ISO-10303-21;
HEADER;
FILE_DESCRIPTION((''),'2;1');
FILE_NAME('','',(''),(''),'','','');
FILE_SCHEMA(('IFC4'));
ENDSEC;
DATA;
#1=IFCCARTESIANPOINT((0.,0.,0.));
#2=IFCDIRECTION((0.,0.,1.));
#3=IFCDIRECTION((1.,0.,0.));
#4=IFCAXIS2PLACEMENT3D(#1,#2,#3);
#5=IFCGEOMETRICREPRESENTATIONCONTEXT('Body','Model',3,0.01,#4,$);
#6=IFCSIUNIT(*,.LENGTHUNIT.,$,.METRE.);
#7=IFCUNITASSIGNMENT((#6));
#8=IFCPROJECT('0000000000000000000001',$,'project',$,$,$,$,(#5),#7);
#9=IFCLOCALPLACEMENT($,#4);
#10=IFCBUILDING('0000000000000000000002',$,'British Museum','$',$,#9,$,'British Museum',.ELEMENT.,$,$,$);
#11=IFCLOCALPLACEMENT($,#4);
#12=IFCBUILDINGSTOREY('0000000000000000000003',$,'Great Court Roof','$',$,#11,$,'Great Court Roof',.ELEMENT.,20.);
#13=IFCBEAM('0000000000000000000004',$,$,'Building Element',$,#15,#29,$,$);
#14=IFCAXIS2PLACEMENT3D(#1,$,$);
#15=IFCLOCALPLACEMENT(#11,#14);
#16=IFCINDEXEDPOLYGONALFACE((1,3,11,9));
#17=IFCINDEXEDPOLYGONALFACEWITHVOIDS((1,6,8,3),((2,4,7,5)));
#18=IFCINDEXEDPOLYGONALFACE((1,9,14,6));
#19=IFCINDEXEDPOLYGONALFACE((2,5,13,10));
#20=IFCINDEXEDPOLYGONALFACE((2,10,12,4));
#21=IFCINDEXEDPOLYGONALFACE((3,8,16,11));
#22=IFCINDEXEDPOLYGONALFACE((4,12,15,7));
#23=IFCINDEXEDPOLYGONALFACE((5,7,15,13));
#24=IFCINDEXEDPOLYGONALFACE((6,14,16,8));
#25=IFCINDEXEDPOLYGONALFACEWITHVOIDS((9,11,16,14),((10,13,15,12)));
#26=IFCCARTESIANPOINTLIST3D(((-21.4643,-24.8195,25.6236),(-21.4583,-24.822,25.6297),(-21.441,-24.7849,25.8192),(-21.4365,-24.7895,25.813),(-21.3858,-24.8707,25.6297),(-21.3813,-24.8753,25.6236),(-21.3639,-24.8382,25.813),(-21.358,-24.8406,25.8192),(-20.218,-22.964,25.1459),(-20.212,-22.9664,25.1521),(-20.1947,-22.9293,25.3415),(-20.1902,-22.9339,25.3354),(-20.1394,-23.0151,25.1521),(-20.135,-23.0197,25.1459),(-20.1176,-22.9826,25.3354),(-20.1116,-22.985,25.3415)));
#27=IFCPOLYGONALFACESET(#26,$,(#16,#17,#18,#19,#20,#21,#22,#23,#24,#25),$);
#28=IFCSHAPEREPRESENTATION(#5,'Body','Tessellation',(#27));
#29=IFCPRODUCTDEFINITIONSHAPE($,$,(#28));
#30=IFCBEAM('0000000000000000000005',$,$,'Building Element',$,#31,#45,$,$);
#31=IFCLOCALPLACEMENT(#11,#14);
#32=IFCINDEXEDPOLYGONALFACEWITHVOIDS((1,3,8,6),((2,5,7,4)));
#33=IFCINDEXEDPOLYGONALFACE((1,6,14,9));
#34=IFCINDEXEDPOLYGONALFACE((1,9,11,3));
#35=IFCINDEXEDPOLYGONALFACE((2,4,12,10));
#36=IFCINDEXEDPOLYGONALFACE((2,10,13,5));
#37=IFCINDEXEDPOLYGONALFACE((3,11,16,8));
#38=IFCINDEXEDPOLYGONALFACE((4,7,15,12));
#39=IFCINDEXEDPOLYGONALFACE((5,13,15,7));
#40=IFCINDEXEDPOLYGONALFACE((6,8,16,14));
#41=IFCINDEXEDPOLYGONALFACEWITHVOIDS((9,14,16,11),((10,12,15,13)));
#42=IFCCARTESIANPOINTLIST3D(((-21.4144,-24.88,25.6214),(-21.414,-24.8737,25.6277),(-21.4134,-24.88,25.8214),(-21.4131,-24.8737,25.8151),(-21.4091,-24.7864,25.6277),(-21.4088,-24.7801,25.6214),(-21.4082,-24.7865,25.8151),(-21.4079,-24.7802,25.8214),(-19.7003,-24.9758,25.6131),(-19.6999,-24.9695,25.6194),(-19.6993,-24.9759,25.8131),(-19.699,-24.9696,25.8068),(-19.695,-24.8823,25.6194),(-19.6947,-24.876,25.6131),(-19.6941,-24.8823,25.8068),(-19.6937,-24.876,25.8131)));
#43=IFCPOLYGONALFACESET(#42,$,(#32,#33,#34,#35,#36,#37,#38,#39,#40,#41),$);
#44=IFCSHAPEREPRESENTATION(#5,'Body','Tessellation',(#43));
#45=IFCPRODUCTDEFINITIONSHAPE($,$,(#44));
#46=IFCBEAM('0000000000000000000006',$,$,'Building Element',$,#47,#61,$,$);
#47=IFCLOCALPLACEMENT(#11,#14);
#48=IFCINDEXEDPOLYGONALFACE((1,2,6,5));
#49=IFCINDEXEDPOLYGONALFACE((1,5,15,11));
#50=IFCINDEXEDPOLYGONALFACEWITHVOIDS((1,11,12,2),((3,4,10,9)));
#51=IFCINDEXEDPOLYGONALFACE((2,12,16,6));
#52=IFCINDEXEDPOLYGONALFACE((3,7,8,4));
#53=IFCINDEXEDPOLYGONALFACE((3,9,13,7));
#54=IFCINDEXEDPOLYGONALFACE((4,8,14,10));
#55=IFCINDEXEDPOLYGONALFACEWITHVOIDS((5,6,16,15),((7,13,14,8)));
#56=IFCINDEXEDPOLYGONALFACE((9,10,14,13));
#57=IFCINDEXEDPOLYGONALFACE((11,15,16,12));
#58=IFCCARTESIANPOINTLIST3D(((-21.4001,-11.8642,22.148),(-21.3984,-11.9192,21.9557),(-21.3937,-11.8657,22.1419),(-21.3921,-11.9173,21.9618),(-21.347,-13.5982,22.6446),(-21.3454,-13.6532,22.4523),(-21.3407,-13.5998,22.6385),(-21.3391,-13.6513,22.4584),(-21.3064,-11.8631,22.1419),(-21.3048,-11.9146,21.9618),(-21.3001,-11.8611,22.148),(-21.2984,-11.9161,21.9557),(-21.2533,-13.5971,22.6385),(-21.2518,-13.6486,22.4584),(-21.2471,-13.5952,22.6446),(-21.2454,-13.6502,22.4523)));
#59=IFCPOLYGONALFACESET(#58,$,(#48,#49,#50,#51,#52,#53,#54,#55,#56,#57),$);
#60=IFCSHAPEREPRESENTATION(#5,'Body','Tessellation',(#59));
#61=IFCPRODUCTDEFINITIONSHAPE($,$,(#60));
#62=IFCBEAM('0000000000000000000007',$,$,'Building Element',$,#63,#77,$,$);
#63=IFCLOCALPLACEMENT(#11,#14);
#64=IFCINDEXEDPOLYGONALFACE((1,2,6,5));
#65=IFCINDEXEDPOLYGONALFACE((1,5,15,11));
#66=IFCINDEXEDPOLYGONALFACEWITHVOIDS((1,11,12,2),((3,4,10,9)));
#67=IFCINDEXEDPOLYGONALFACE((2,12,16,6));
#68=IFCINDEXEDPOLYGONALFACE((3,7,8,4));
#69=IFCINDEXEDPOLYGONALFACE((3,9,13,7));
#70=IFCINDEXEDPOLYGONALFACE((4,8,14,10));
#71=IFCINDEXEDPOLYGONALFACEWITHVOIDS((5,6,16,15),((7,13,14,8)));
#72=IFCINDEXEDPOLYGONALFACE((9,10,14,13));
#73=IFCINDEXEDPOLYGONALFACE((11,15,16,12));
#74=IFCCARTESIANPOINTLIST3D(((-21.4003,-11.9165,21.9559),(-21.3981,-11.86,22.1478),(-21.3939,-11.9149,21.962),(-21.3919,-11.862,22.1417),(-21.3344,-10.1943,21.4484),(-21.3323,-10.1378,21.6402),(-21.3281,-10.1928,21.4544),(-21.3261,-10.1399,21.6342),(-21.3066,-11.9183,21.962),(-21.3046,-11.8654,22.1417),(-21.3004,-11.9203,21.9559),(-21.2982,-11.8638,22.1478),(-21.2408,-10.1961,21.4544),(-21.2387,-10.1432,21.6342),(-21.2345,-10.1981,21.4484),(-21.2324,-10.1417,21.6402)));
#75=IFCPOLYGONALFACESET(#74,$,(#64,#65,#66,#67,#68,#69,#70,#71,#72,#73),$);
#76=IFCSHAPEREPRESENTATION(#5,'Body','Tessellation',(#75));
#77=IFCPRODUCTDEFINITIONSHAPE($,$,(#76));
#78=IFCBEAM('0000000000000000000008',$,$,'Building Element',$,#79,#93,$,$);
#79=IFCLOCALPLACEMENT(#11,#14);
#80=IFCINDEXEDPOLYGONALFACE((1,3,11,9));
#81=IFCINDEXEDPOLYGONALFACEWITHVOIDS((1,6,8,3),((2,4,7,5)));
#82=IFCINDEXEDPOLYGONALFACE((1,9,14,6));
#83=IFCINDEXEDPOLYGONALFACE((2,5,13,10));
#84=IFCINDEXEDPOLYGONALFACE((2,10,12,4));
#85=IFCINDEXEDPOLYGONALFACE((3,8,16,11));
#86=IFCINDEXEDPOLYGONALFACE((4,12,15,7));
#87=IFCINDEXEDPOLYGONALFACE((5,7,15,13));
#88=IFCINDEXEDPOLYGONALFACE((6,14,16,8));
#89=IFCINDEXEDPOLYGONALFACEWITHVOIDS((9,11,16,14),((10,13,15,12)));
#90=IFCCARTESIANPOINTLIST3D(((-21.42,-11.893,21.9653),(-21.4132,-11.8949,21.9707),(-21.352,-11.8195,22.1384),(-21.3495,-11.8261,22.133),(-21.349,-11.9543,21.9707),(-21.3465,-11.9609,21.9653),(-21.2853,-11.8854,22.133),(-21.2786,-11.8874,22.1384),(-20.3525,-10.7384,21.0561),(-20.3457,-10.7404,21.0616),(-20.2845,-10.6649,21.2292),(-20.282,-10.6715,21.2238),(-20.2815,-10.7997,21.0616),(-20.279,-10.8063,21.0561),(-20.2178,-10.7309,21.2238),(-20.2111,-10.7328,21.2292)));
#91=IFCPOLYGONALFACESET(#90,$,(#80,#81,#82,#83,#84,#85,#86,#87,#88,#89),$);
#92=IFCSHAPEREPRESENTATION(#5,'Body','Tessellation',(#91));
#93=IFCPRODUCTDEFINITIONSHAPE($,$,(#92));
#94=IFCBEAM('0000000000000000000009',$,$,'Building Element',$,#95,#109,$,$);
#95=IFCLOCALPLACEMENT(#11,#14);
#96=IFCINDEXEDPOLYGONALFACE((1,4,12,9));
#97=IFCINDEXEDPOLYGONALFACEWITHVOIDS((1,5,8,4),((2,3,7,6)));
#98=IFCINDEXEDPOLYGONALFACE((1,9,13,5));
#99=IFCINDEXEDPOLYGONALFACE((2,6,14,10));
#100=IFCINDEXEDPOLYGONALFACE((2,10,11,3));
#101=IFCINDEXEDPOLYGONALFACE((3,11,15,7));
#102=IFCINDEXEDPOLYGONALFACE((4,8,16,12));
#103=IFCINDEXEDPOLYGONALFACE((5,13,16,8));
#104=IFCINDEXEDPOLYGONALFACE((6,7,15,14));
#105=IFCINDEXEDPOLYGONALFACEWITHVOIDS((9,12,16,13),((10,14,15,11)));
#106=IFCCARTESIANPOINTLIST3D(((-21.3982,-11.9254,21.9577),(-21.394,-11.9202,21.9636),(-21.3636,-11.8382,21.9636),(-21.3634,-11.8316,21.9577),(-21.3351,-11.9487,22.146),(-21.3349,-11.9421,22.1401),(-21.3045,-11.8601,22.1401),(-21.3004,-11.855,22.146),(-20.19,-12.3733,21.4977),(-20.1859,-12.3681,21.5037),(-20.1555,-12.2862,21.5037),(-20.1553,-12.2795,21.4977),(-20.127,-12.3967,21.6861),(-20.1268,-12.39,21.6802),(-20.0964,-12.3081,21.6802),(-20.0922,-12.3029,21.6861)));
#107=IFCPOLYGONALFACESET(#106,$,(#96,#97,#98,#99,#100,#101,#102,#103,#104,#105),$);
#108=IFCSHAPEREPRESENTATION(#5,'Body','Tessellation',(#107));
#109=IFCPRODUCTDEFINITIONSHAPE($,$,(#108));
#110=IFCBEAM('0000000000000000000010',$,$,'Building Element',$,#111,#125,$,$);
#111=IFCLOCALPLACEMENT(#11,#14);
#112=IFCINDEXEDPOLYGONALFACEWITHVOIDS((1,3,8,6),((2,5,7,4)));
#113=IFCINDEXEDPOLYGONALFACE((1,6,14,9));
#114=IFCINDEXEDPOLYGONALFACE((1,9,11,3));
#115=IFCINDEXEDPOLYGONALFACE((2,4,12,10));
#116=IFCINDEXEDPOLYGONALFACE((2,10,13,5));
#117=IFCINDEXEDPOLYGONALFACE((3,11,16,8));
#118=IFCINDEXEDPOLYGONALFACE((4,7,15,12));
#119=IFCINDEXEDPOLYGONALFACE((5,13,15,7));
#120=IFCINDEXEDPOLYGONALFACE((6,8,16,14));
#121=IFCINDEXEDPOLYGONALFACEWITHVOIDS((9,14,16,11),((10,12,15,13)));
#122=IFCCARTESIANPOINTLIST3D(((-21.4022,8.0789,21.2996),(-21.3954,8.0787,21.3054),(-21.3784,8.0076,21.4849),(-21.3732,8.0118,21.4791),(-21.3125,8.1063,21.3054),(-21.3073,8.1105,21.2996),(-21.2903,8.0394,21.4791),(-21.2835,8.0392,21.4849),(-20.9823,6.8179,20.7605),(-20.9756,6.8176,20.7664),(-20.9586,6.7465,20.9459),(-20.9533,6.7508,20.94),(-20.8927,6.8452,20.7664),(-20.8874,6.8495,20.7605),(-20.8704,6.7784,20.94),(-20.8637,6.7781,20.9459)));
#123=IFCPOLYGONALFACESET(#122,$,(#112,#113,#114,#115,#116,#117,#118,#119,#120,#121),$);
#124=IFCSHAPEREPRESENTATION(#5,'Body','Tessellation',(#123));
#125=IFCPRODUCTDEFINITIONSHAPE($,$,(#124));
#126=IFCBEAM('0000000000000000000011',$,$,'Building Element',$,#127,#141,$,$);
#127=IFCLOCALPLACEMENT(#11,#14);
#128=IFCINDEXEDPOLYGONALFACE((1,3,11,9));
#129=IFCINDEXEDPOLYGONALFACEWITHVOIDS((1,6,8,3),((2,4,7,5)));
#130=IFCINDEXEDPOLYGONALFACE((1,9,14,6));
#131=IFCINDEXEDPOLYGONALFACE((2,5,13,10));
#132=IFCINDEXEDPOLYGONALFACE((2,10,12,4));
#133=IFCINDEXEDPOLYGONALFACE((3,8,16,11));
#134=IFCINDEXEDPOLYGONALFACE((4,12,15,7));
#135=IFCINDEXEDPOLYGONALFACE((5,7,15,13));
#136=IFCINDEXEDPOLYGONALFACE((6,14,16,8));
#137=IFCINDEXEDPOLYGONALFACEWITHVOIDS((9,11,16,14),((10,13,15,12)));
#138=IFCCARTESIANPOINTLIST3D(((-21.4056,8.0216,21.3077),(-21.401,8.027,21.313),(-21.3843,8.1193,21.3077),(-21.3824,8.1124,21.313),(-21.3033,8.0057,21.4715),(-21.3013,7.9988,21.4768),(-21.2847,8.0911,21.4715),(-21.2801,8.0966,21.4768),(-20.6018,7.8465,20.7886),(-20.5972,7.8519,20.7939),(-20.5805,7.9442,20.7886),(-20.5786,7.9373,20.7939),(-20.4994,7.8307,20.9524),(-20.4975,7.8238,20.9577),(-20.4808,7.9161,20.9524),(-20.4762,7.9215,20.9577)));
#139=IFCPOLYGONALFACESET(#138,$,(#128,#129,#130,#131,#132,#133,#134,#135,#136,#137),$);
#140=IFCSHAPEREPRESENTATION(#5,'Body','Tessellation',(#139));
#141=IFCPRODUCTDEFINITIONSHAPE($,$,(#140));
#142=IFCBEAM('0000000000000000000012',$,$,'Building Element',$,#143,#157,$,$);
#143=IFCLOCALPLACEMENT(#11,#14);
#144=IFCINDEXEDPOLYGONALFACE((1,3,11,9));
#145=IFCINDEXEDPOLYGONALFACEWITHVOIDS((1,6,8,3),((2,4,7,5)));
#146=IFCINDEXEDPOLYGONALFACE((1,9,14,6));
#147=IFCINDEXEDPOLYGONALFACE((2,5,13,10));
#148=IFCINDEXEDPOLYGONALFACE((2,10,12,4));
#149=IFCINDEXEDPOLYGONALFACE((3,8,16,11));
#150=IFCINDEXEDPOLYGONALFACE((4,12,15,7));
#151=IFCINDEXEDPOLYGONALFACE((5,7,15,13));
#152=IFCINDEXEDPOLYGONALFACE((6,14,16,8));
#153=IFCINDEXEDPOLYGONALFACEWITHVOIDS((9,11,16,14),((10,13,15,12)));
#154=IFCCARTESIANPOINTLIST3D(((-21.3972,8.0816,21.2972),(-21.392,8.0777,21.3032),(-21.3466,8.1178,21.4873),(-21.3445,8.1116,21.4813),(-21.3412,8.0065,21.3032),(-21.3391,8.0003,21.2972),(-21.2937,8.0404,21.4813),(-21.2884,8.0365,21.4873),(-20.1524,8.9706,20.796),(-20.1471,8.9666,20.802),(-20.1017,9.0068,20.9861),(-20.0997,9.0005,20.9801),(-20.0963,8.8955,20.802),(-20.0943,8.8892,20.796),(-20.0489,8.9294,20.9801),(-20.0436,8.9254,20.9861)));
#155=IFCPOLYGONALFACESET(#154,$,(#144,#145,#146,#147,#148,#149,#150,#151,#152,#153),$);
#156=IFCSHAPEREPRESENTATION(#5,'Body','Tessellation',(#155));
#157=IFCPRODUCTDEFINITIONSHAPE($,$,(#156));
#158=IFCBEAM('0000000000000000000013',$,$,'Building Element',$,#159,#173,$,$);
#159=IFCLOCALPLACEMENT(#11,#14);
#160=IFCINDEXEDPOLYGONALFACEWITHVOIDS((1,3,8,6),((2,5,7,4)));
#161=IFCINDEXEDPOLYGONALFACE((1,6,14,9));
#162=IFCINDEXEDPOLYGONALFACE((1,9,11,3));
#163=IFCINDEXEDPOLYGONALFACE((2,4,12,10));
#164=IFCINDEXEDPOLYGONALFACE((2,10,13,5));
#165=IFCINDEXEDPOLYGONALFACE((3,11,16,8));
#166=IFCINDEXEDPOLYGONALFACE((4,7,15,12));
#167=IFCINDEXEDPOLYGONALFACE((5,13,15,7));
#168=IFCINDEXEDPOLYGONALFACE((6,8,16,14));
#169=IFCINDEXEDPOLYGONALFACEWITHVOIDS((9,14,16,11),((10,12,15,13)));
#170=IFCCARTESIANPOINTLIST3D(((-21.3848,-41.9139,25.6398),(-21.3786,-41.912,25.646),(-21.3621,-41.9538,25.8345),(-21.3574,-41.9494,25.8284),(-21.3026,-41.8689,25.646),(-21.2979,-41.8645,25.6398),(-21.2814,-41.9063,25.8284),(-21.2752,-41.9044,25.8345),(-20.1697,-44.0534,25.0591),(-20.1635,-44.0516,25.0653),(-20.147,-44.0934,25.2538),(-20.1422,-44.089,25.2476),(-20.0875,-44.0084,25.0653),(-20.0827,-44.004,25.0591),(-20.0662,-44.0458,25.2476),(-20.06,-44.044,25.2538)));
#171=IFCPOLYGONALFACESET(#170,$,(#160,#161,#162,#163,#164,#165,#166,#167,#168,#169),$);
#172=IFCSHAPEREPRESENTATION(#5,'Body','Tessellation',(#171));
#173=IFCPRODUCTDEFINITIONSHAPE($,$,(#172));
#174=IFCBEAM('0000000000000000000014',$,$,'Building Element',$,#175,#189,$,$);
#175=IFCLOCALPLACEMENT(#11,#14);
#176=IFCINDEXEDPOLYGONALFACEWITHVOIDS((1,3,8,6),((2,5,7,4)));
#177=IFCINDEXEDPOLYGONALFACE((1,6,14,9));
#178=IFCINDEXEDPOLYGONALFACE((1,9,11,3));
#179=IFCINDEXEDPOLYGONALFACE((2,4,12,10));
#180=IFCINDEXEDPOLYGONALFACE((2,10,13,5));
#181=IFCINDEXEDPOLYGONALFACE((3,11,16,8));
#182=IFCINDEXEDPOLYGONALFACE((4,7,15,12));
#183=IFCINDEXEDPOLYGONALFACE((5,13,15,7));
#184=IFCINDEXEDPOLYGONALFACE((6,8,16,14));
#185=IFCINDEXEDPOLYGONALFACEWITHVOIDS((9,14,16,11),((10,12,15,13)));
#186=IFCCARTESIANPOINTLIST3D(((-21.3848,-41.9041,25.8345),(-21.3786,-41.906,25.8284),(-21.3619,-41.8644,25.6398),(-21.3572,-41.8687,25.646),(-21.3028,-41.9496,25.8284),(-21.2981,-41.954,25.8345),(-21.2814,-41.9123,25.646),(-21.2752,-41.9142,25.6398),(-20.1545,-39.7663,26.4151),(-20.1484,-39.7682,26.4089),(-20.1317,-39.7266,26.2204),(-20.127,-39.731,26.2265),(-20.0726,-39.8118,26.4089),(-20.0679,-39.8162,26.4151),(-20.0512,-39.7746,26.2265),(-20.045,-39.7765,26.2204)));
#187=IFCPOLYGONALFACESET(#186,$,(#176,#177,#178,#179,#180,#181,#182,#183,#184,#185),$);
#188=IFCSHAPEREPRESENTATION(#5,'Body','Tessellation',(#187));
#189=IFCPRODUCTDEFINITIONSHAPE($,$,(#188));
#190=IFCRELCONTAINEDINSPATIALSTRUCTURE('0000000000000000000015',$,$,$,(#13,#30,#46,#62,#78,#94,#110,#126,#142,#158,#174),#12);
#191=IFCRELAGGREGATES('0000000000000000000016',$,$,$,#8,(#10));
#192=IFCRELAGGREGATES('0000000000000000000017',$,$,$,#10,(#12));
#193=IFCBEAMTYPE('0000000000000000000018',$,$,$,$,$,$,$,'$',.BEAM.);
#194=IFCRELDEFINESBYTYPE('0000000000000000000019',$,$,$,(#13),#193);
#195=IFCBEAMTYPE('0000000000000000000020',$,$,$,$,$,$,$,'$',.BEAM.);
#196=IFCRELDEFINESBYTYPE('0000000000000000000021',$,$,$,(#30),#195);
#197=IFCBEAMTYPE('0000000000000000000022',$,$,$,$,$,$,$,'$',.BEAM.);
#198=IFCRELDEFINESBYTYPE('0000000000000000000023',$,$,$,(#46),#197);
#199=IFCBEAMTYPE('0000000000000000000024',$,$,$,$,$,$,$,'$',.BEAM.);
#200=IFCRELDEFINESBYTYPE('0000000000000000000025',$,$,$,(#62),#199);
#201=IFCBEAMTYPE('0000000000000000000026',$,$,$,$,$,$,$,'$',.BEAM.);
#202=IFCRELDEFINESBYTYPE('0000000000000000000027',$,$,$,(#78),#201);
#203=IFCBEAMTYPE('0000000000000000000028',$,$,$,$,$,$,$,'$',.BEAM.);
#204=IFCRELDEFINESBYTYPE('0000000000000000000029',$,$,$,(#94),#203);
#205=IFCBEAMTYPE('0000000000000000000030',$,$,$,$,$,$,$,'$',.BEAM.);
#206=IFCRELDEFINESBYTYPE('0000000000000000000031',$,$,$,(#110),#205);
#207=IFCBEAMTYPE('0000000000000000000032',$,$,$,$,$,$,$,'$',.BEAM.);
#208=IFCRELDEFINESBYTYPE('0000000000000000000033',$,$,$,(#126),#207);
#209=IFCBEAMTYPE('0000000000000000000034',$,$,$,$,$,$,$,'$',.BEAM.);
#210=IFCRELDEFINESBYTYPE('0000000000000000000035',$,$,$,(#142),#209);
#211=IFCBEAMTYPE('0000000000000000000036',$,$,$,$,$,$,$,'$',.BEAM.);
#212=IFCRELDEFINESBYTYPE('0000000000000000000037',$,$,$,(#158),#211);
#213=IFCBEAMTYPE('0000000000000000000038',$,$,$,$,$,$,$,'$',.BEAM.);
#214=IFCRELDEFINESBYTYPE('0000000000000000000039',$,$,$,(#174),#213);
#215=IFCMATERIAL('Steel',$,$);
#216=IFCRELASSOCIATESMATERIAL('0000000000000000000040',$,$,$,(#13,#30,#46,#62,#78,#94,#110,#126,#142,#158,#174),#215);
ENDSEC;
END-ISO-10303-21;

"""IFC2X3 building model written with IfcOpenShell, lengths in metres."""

from ifc_helpers import new_model, si_unit, frame, origin_with_axes, origin_2d, place, context, project, spatial, hollow_rectangle, extrude, material, type_object, element, save


model = new_model("IFC2X3")

# Units and contexts
model_context = context("Model", 3, precision=0.01, world=origin_with_axes(), identifier="Body")
ifc_project = project(units=[si_unit("LENGTHUNIT", "METRE")], contexts=[model_context])

# Building, storey
building_placement = place(None, origin_with_axes())
building = spatial("IfcBuilding", under=ifc_project, at=building_placement, Name="British Museum", Description="$", LongName="British Museum", CompositionType="ELEMENT")
storey_placement = place(None, origin_with_axes())
storey = spatial("IfcBuildingStorey", under=building, at=storey_placement, Name="Great Court Roof", Description="$", LongName="Great Court Roof", CompositionType="ELEMENT", Elevation=20.0)

# Beams
ifc_material = material(Name="Steel")
beam_type_1 = type_object("IfcBeamType", ElementType="$", PredefinedType="BEAM")
beam_1_placement = place(None, origin_with_axes())
element("IfcBeam", 1, at=beam_1_placement, inside=storey, type_object=beam_type_1, material=ifc_material, Description="Building Element", context=model_context, shape_type="SweptSolid", body=[
    extrude(hollow_rectangle(XDim=0.1, YDim=0.2, WallThickness=0.0063, InnerFilletRadius=-0.0063, OuterFilletRadius=0.0, at=origin_2d()), frame((-21.4111, -24.8301, 25.7214), z_axis=(0.545259, 0.811803, -0.208972), x_axis=(-0.830131, 0.557569, 0.0)), (0.0, 0.0, 1.0), 2.2857),
])
beam_type_2 = type_object("IfcBeamType", ElementType="$", PredefinedType="BEAM")
beam_2_placement = place(None, origin_with_axes())
element("IfcBeam", 2, at=beam_2_placement, inside=storey, type_object=beam_type_2, material=ifc_material, Description="Building Element", context=model_context, shape_type="SweptSolid", body=[
    extrude(hollow_rectangle(XDim=0.1, YDim=0.2, WallThickness=0.0063, InnerFilletRadius=-0.0063, OuterFilletRadius=0.0, at=origin_2d()), frame((-21.4111, -24.8301, 25.7214), z_axis=(0.998428, -0.055838, -0.004846), x_axis=(0.055839, 0.99844, 0.0)), (0.0, 0.0, 1.0), 1.7168),
])
beam_type_3 = type_object("IfcBeamType", ElementType="$", PredefinedType="BEAM")
beam_3_placement = place(None, origin_with_axes())
element("IfcBeam", 3, at=beam_3_placement, inside=storey, type_object=beam_type_3, material=ifc_material, Description="Building Element", context=model_context, shape_type="SweptSolid", body=[
    extrude(hollow_rectangle(XDim=0.1, YDim=0.2, WallThickness=0.0063, InnerFilletRadius=-0.0063, OuterFilletRadius=0.0, at=origin_2d()), frame((-21.3493, -11.8902, 22.0519), z_axis=(0.029389, -0.960938, 0.275198), x_axis=(0.999533, 0.030569, 0.0)), (0.0, 0.0, 1.0), 1.8045),
])
beam_type_4 = type_object("IfcBeamType", ElementType="$", PredefinedType="BEAM")
beam_4_placement = place(None, origin_with_axes())
element("IfcBeam", 4, at=beam_4_placement, inside=storey, type_object=beam_type_4, material=ifc_material, Description="Building Element", context=model_context, shape_type="SweptSolid", body=[
    extrude(hollow_rectangle(XDim=0.1, YDim=0.2, WallThickness=0.0063, InnerFilletRadius=-0.0063, OuterFilletRadius=0.0, at=origin_2d()), frame((-21.3493, -11.8902, 22.0519), z_axis=(0.036652, 0.958567, -0.282498), x_axis=(-0.99927, 0.038208, 0.0)), (0.0, 0.0, 1.0), 1.7966),
])
beam_type_5 = type_object("IfcBeamType", ElementType="$", PredefinedType="BEAM")
beam_5_placement = place(None, origin_with_axes())
element("IfcBeam", 5, at=beam_5_placement, inside=storey, type_object=beam_type_5, material=ifc_material, Description="Building Element", context=model_context, shape_type="SweptSolid", body=[
    extrude(hollow_rectangle(XDim=0.1, YDim=0.2, WallThickness=0.0063, InnerFilletRadius=-0.0063, OuterFilletRadius=0.0, at=origin_2d()), frame((-21.3493, -11.8902, 22.0519), z_axis=(0.587713, 0.635637, -0.500558), x_axis=(-0.734244, 0.678886, 0.0)), (0.0, 0.0, 1.0), 1.8163),
])
beam_type_6 = type_object("IfcBeamType", ElementType="$", PredefinedType="BEAM")
beam_6_placement = place(None, origin_with_axes())
element("IfcBeam", 6, at=beam_6_placement, inside=storey, type_object=beam_type_6, material=ifc_material, Description="Building Element", context=model_context, shape_type="SweptSolid", body=[
    extrude(hollow_rectangle(XDim=0.1, YDim=0.2, WallThickness=0.0063, InnerFilletRadius=-0.0063, OuterFilletRadius=0.0, at=origin_2d()), frame((-21.3493, -11.8902, 22.0519), z_axis=(0.883054, -0.327402, -0.33619), x_axis=(0.347636, 0.937629, 0.0)), (0.0, 0.0, 1.0), 1.3681),
])
beam_type_7 = type_object("IfcBeamType", ElementType="$", PredefinedType="BEAM")
beam_7_placement = place(None, origin_with_axes())
element("IfcBeam", 7, at=beam_7_placement, inside=storey, type_object=beam_type_7, material=ifc_material, Description="Building Element", context=model_context, shape_type="SweptSolid", body=[
    extrude(hollow_rectangle(XDim=0.1, YDim=0.2, WallThickness=0.0063, InnerFilletRadius=-0.0063, OuterFilletRadius=0.0, at=origin_2d()), frame((-21.3428, 8.0591, 21.3922), z_axis=(0.292727, -0.87924, -0.375828), x_axis=(0.948798, 0.315885, 0.0)), (0.0, 0.0, 1.0), 1.4343),
])
beam_type_8 = type_object("IfcBeamType", ElementType="$", PredefinedType="BEAM")
beam_8_placement = place(None, origin_with_axes())
element("IfcBeam", 8, at=beam_8_placement, inside=storey, type_object=beam_type_8, material=ifc_material, Description="Building Element", context=model_context, shape_type="SweptSolid", body=[
    extrude(hollow_rectangle(XDim=0.1, YDim=0.2, WallThickness=0.0063, InnerFilletRadius=-0.0063, OuterFilletRadius=0.0, at=origin_2d()), frame((-21.3428, 8.0591, 21.3922), z_axis=(0.826368, -0.179956, -0.533602), x_axis=(0.212781, 0.9771, 0.0)), (0.0, 0.0, 1.0), 0.9727),
])
beam_type_9 = type_object("IfcBeamType", ElementType="$", PredefinedType="BEAM")
beam_9_placement = place(None, origin_with_axes())
element("IfcBeam", 9, at=beam_9_placement, inside=storey, type_object=beam_type_9, material=ifc_material, Description="Building Element", context=model_context, shape_type="SweptSolid", body=[
    extrude(hollow_rectangle(XDim=0.1, YDim=0.2, WallThickness=0.0063, InnerFilletRadius=-0.0063, OuterFilletRadius=0.0, at=origin_2d()), frame((-21.3428, 8.0591, 21.3922), z_axis=(0.773353, 0.552255, -0.31135), x_axis=(-0.581141, 0.813803, 0.0)), (0.0, 0.0, 1.0), 1.6097),
])
beam_type_10 = type_object("IfcBeamType", ElementType="$", PredefinedType="BEAM")
beam_10_placement = place(None, origin_with_axes())
element("IfcBeam", 10, at=beam_10_placement, inside=storey, type_object=beam_type_10, material=ifc_material, Description="Building Element", context=model_context, shape_type="SweptSolid", body=[
    extrude(hollow_rectangle(XDim=0.1, YDim=0.2, WallThickness=0.0063, InnerFilletRadius=-0.0063, OuterFilletRadius=0.0, at=origin_2d()), frame((-21.33, -41.9092, 25.7372), z_axis=(0.480654, -0.846292, -0.229698), x_axis=(0.869542, 0.493859, 0.0)), (0.0, 0.0, 1.0), 2.5282),
])
beam_type_11 = type_object("IfcBeamType", ElementType="$", PredefinedType="BEAM")
beam_11_placement = place(None, origin_with_axes())
element("IfcBeam", 11, at=beam_11_placement, inside=storey, type_object=beam_type_11, material=ifc_material, Description="Building Element", context=model_context, shape_type="SweptSolid", body=[
    extrude(hollow_rectangle(XDim=0.1, YDim=0.2, WallThickness=0.0063, InnerFilletRadius=-0.0063, OuterFilletRadius=0.0, at=origin_2d()), frame((-21.33, -41.9092, 25.7372), z_axis=(0.485508, 0.843674, 0.22912), x_axis=(-0.866731, 0.498776, 0.0)), (0.0, 0.0, 1.0), 2.5339),
])

save(model, "model.ifc")
